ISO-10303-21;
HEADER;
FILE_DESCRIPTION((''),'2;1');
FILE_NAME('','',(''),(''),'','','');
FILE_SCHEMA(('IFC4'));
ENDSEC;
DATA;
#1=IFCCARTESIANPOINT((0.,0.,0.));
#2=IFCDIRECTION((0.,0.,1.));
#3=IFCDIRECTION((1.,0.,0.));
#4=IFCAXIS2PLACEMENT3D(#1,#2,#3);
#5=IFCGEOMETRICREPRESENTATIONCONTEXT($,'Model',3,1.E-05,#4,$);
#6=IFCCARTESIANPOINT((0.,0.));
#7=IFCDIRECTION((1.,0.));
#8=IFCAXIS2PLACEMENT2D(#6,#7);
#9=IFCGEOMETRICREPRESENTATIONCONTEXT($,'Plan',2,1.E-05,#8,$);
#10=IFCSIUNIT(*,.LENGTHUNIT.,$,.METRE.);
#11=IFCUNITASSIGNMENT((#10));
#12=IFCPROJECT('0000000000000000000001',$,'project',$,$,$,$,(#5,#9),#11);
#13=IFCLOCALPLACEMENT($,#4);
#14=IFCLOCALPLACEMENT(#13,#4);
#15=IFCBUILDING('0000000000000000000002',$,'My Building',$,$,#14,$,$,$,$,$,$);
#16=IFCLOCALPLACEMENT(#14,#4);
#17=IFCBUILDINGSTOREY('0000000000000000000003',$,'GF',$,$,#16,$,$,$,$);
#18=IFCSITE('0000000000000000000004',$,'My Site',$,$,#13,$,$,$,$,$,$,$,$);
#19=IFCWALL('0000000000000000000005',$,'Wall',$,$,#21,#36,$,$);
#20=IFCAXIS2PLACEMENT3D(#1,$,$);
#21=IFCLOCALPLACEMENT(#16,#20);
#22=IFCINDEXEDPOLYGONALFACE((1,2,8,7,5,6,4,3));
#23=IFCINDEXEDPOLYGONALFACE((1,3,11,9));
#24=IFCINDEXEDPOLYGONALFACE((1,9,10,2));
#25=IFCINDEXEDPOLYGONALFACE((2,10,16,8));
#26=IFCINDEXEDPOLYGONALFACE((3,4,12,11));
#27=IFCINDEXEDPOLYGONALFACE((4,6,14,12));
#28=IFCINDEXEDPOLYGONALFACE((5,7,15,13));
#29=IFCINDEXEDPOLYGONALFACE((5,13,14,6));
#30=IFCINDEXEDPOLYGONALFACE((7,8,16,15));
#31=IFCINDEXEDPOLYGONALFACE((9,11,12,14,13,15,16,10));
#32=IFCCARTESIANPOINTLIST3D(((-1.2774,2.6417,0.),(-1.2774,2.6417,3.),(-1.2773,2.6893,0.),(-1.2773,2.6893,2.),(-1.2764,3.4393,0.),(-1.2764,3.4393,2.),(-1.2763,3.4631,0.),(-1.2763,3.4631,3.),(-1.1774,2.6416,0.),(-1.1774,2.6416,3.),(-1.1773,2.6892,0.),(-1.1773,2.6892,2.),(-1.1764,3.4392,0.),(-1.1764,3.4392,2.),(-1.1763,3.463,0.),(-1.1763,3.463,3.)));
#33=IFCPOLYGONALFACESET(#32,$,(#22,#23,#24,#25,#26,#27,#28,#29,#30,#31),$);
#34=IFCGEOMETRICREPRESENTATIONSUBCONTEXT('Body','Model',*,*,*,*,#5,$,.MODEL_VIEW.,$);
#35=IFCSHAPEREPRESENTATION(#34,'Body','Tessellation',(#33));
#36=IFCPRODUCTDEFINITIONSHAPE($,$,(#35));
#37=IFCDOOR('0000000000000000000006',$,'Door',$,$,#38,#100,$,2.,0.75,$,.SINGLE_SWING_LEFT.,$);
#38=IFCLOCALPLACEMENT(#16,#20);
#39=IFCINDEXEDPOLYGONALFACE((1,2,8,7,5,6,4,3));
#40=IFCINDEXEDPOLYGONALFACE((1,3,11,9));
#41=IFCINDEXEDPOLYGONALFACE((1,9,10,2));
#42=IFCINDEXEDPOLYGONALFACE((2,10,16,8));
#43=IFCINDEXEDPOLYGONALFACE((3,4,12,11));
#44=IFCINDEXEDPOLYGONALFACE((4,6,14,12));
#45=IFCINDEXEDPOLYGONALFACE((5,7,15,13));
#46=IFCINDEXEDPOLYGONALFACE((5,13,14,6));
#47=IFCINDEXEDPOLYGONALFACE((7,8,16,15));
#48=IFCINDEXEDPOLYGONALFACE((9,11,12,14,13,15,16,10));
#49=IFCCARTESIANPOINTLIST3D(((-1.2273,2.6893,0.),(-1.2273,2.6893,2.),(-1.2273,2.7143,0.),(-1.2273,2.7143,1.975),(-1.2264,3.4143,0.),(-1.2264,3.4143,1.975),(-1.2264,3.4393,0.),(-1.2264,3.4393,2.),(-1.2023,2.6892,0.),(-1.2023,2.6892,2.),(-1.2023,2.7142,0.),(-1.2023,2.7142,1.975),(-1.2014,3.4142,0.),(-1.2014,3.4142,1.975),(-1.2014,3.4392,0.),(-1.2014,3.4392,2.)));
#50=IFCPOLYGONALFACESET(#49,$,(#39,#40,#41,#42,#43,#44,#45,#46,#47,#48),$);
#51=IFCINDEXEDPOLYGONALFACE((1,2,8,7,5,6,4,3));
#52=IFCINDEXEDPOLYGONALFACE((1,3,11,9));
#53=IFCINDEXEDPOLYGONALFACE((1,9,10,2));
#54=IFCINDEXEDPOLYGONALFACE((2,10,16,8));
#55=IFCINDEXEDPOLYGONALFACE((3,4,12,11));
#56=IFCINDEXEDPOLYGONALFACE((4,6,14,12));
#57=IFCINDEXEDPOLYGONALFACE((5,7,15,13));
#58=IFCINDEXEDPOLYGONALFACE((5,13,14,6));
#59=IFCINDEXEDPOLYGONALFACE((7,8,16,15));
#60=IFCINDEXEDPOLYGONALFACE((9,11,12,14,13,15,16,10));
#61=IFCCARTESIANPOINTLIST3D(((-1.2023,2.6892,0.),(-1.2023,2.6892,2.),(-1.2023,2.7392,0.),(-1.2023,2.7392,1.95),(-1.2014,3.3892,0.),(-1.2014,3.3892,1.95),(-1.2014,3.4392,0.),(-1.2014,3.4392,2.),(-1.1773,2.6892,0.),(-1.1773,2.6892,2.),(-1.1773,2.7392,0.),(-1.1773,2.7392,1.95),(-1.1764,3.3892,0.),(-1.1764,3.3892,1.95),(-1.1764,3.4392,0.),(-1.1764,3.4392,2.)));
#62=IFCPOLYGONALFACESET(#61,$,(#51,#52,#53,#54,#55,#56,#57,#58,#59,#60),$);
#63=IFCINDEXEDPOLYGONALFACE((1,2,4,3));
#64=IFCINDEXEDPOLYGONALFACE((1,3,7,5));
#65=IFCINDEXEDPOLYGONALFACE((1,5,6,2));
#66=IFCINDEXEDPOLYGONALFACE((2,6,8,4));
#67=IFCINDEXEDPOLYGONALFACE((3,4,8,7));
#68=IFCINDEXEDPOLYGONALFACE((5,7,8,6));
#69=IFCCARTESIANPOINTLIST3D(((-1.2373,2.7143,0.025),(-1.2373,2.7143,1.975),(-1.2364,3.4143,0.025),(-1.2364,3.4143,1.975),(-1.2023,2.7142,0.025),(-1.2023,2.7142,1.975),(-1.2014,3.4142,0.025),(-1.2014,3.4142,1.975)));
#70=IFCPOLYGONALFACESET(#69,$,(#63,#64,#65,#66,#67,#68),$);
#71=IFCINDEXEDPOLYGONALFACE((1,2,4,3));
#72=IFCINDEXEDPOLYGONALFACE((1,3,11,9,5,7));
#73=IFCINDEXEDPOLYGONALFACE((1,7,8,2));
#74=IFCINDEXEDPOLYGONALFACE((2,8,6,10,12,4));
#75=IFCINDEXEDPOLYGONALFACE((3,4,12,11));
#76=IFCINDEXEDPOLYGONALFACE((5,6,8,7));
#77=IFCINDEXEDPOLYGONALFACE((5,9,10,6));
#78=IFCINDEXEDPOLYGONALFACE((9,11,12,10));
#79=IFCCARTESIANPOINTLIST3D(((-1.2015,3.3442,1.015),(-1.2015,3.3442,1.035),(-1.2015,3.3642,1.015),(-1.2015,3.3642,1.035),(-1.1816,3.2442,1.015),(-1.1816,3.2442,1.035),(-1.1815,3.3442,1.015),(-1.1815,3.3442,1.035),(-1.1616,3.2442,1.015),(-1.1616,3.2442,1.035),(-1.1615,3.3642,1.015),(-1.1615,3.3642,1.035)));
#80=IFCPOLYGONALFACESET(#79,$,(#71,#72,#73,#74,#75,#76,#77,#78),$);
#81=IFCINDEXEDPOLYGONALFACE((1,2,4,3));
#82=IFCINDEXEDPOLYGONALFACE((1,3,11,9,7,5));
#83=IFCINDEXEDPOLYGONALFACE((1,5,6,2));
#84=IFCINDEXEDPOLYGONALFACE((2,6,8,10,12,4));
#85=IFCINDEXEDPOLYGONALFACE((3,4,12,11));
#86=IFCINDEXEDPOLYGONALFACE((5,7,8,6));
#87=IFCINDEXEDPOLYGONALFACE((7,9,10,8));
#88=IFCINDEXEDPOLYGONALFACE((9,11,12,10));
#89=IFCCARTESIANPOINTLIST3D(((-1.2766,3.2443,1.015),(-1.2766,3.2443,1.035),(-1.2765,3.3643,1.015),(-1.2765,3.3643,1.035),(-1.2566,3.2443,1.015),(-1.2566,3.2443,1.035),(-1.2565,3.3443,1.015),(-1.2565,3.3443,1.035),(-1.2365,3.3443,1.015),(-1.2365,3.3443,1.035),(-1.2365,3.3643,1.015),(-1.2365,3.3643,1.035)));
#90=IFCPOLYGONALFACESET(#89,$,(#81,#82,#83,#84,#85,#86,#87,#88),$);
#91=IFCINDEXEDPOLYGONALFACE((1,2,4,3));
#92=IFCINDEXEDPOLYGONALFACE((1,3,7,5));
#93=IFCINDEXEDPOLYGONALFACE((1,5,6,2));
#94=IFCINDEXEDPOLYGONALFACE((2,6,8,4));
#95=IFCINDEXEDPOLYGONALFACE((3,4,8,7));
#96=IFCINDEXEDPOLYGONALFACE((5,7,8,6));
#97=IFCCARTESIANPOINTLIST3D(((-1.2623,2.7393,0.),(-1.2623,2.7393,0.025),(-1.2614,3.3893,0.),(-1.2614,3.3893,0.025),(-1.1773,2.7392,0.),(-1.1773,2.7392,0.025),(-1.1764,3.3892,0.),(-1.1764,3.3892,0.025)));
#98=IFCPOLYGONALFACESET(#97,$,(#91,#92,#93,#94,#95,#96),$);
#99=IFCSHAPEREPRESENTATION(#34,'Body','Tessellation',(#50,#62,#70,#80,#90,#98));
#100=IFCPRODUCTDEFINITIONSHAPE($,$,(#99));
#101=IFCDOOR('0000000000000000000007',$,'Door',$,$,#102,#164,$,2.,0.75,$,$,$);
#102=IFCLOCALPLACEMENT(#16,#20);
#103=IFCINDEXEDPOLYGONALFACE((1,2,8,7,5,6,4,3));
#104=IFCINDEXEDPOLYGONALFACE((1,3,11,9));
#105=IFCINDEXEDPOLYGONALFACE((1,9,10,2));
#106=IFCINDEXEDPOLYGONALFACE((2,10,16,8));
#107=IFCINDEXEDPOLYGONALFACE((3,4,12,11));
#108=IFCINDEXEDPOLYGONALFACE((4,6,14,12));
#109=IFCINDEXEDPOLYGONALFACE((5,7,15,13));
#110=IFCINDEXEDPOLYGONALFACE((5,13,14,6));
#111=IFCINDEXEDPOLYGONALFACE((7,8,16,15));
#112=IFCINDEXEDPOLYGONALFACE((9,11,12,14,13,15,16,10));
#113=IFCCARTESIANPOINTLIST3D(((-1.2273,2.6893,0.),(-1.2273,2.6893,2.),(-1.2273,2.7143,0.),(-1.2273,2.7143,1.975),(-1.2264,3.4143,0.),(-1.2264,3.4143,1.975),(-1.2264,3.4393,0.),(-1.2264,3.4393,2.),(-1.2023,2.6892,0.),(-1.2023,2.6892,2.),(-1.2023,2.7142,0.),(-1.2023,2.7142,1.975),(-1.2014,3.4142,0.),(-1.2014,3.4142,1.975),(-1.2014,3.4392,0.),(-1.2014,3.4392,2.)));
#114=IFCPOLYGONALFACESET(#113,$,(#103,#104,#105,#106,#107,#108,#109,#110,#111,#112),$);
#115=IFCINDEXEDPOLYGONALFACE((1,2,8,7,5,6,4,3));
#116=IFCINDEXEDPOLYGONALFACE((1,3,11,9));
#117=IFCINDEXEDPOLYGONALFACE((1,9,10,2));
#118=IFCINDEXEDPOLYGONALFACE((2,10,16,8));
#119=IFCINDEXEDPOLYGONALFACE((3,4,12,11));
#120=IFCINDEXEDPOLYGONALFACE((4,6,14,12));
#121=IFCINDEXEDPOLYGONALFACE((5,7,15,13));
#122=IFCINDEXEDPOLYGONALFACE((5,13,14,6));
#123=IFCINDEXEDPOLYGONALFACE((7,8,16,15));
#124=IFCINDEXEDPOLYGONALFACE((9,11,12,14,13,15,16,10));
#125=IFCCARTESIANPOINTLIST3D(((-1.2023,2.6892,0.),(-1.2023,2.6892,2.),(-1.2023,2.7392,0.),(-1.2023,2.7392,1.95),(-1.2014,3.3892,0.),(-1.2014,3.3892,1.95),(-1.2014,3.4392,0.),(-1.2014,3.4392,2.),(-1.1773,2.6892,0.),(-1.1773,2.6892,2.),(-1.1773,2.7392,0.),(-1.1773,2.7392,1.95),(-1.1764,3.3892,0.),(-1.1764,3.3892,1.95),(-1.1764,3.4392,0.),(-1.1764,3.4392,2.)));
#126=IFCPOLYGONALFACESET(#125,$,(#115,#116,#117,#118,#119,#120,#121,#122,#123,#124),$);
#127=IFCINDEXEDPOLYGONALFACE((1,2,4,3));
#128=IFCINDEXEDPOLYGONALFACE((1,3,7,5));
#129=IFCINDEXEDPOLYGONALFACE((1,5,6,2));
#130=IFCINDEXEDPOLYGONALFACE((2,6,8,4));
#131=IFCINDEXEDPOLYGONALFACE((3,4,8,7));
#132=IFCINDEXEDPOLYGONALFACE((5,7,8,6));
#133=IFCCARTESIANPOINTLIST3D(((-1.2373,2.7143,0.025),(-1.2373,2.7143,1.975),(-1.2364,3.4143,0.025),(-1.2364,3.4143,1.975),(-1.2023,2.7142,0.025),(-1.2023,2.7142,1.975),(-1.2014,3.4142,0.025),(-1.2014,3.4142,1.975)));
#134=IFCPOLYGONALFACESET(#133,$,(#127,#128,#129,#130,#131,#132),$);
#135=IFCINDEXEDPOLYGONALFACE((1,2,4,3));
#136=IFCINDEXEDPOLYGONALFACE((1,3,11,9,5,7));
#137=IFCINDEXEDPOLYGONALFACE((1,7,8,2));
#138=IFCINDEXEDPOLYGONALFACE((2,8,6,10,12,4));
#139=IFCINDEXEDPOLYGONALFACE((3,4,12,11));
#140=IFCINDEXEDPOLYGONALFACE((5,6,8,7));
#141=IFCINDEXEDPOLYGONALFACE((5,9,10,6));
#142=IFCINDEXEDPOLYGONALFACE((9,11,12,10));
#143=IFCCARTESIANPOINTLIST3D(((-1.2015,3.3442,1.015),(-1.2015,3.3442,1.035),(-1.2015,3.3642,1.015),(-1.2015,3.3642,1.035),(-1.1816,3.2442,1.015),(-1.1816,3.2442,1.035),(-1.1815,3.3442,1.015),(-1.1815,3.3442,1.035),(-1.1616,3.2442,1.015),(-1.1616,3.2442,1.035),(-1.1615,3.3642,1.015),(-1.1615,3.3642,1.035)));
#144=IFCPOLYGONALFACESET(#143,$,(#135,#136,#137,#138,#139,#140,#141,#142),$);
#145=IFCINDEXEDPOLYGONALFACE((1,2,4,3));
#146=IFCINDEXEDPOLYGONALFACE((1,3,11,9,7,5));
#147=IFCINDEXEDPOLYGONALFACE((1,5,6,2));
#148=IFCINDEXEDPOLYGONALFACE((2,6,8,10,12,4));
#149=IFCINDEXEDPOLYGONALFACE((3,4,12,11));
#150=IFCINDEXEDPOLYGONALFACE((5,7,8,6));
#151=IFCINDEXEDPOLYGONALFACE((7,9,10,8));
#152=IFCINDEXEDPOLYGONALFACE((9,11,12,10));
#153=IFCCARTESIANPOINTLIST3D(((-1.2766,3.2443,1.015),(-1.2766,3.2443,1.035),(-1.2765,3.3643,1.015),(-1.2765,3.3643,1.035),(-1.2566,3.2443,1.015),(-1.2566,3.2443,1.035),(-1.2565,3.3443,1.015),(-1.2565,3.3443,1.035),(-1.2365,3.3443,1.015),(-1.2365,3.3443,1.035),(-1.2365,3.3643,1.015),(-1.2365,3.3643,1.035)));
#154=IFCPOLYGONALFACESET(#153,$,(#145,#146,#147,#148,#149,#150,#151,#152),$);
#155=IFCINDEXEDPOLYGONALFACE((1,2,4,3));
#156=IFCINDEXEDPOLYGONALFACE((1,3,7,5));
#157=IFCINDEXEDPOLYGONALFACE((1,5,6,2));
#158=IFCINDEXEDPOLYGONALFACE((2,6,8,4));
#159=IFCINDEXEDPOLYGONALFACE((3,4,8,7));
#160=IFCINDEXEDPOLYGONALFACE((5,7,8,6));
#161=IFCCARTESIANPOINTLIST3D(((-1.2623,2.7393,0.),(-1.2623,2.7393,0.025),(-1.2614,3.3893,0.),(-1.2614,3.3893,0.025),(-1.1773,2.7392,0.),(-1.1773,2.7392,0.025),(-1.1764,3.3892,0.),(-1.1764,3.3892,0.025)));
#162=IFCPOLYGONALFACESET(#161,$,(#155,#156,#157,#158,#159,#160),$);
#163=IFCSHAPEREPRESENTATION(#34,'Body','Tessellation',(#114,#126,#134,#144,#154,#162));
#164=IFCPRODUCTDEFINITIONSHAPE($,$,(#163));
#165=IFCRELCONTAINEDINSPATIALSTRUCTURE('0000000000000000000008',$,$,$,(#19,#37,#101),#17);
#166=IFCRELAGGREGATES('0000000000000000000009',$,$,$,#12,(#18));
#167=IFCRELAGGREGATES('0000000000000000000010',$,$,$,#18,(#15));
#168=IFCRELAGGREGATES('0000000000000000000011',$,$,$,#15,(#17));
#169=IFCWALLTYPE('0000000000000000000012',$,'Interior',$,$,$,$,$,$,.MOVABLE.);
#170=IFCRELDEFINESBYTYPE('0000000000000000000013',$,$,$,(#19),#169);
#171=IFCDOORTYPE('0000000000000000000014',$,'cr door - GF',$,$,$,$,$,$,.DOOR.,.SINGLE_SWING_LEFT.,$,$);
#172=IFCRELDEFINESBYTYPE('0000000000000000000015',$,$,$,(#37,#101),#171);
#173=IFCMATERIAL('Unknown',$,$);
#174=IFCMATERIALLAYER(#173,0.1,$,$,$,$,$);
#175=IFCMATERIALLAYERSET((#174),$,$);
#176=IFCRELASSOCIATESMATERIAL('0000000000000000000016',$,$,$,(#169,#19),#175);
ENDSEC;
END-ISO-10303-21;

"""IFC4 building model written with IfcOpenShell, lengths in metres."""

from ifc_helpers import new_model, entity, si_unit, frame, origin_with_axes, origin_2d_with_axis, place, context, subcontext, project, spatial, line, indexed_curve, outline, extrude, shape, source, transform, mapped, material, layer, layer_set, layer_usage, type_object, type_shapes, element, fill, save


model = new_model("IFC4")

# Units and contexts
model_context = context("Model", 3, precision=1e-05, world=origin_with_axes())
plan_context = context("Plan", 2, precision=1e-05, world=origin_2d_with_axis())
body_context_1 = subcontext(model_context, "Body", "Model", "MODEL_VIEW")
body_context_2 = subcontext(plan_context, "Body", "Plan", "PLAN_VIEW")
ifc_project = project(units=[si_unit("LENGTHUNIT", "METRE")], contexts=[model_context, plan_context])

# Site, building, storey
site_placement = place(None, origin_with_axes())
site = spatial("IfcSite", under=ifc_project, at=site_placement, Name="My Site")
building_placement = place(site_placement, origin_with_axes())
building = spatial("IfcBuilding", under=site, at=building_placement, Name="My Building")
storey_placement = place(building_placement, origin_with_axes())
storey = spatial("IfcBuildingStorey", under=building, at=storey_placement, Name="GF")

# Shared definitions
ifc_material = material(Name="Unknown")

# Shared definitions
ifc_layer_1 = layer(ifc_material, 0.1)
ifc_layer_set_1 = layer_set([ifc_layer_1])
wall_type_1 = type_object("IfcWallType", Name="Interior", PredefinedType="MOVABLE", material=ifc_layer_set_1)

# Wall, openings, doors
ifc_layer_usage_1 = layer_usage(ifc_layer_set_1, "AXIS2", "POSITIVE", 0.0)
wall_1_placement = place(storey_placement, frame((-1.2763, 3.4631, 0.0), z_axis=(0.0, 0.0, 1.0), x_axis=(-0.001302, -0.999999, 0.0)))
wall_1 = element("IfcWall", 1, at=wall_1_placement, inside=storey, type_object=wall_type_1, material=ifc_layer_usage_1, Name="Wall", context=body_context_1, shape_type="SweptSolid", body=[
    extrude(outline(indexed_curve([(0.0, 0.0), (0.0, 0.1), (0.8215, 0.1), (0.8215, 0.0)], segments=[line(1, 2, 3, 4, 1)])), origin_with_axes(), (0.0, 0.0, 1.0), 3.0),
])
shared_shape_1 = source(origin_with_axes(), body_context_1, "Body", "SweptSolid", [
    extrude(outline(indexed_curve([(0.0, 0.0), (0.75, 0.0), (0.75, 2.0), (0.0, 2.0)], segments=[line(1, 2, 3, 4, 1)])), frame((0.0, -0.6, 0.0), z_axis=(0.0, -1.0, 0.0), x_axis=(1.0, 0.0, 0.0)), (0.0, 0.0, -1.0), 1.2),
])
opening_1_placement = place(wall_1_placement, frame((0.7738, 0.1, 0.0), z_axis=(0.0, 0.0, 1.0), x_axis=(-1.0, 0.0, 0.0)))
opening_1 = element("IfcOpeningElement", 2, at=opening_1_placement, cuts=wall_1, PredefinedType="OPENING", context=body_context_1, shape_type="MappedRepresentation", body=[
    mapped(shared_shape_1, transform((0.0, 0.0, 0.0), x_axis=(1.0, 0.0, 0.0), y_axis=(0.0, 1.0, 0.0), z_axis=(0.0, 0.0, 1.0), scale=1.0)),
])
opening_2_placement = place(wall_1_placement, frame((0.7738, 0.1, 0.0), z_axis=(0.0, 0.0, 1.0), x_axis=(-1.0, 0.0, 0.0)))
opening_2 = element("IfcOpeningElement", 3, at=opening_2_placement, cuts=wall_1, PredefinedType="OPENING", context=body_context_1, shape_type="MappedRepresentation", body=[
    mapped(shared_shape_1, transform((0.0, 0.0, 0.0), x_axis=(1.0, 0.0, 0.0), y_axis=(0.0, 1.0, 0.0), z_axis=(0.0, 0.0, 1.0), scale=1.0)),
])
door_type_1 = type_object("IfcDoorType", Name="cr door - GF", OperationType="SINGLE_SWING_LEFT", PredefinedType="DOOR")
shared_shape_2 = source(origin_with_axes(), body_context_1, "Body", "SweptSolid", [
    extrude(outline(indexed_curve([(0.0, 0.0), (0.0, 2.0), (0.75, 2.0), (0.75, 0.0), (0.725, 0.0), (0.725, 1.975), (0.025, 1.975), (0.025, 0.0)], segments=[line(1, 2, 3, 4, 5, 6, 7, 8, 1)])), frame((0.0, 0.025, 0.0), z_axis=(0.0, -1.0, 0.0), x_axis=(1.0, 0.0, 0.0)), (0.0, 0.0, -1.0), 0.025),
    extrude(outline(indexed_curve([(0.0, 0.0), (0.0, 2.0), (0.75, 2.0), (0.75, 0.0), (0.7, 0.0), (0.7, 1.95), (0.05, 1.95), (0.05, 0.0)], segments=[line(1, 2, 3, 4, 5, 6, 7, 8, 1)])), frame((0.0, 0.0, 0.0), z_axis=(0.0, -1.0, 0.0), x_axis=(1.0, 0.0, 0.0)), (0.0, 0.0, -1.0), 0.025),
    extrude(outline(indexed_curve([(0.0, 0.0), (0.7, 0.0), (0.7, 0.035), (0.0, 0.035)], segments=[line(1, 2, 3, 4, 1)])), frame((0.025, 0.025, 0.025), z_axis=(0.0, 0.0, 1.0), x_axis=(1.0, 0.0, 0.0)), (0.0, 0.0, 1.0), 1.95),
    extrude(outline(indexed_curve([(0.0, 0.0), (0.0, -0.04), (-0.12, -0.04), (-0.12, -0.02), (-0.02, -0.02), (-0.02, 0.0)], segments=[line(1, 2, 3, 4, 5, 6, 1)])), frame((0.675, 0.025, 1.015), z_axis=(0.0, 0.0, 1.0), x_axis=(1.0, 0.0, 0.0)), (0.0, 0.0, 1.0), 0.02),
    extrude(outline(indexed_curve([(0.0, 0.0), (0.0, 0.04), (-0.12, 0.04), (-0.12, 0.02), (-0.02, 0.02), (-0.02, 0.0)], segments=[line(1, 2, 3, 4, 5, 6, 1)])), frame((0.675, 0.06, 1.015), z_axis=(0.0, 0.0, 1.0), x_axis=(1.0, 0.0, 0.0)), (0.0, 0.0, 1.0), 0.02),
    extrude(outline(indexed_curve([(0.0, 0.0), (0.65, 0.0), (0.65, 0.085), (0.0, 0.085)], segments=[line(1, 2, 3, 4, 1)])), frame((0.05, 0.0, 0.0), z_axis=(0.0, 0.0, 1.0), x_axis=(1.0, 0.0, 0.0)), (0.0, 0.0, 1.0), 0.025),
])
shared_shape_3 = source(origin_with_axes(), body_context_2, "Body", "Curve2D", [
    entity("IfcIndexedPolyCurve", entity("IfcCartesianPointList2D", [[0.0, 0.0], [0.0, 0.05], [0.025, 0.05], [0.025, 0.025], [0.05, 0.025], [0.05, 0.0]]), [entity("IfcLineIndex", [1, 2, 3, 4, 5, 6, 1])]),
    entity("IfcIndexedPolyCurve", entity("IfcCartesianPointList2D", [[0.75, 0.0], [0.75, 0.05], [0.725, 0.05], [0.725, 0.025], [0.7, 0.025], [0.7, 0.0]]), [entity("IfcLineIndex", [1, 2, 3, 4, 5, 6, 1])]),
    entity("IfcTrimmedCurve", entity("IfcEllipse", entity("IfcAxis2Placement2D", entity("IfcCartesianPoint", [0.06, 0.05]), entity("IfcDirection", [1.0, 0.0])), 0.665, 0.7), [entity("IfcCartesianPoint", [0.725, 0.05])], [entity("IfcCartesianPoint", [0.06, 0.75])], True, "CARTESIAN"),
    entity("IfcIndexedPolyCurve", entity("IfcCartesianPointList2D", [[0.025, 0.05], [0.06, 0.05], [0.06, 0.75], [0.025, 0.75]]), [entity("IfcLineIndex", [1, 2, 3, 4, 1])]),
])
type_shapes(door_type_1, [shared_shape_2, shared_shape_3])
door_1_placement = place(opening_1_placement, frame((0.0, 0.0, 0.0), z_axis=(0.0, 0.0, 1.0), x_axis=(1.0, 0.0, 0.0)))
door_1 = element("IfcDoor", 4, at=door_1_placement, inside=storey, type_object=door_type_1, Name="Door", OperationType="SINGLE_SWING_LEFT", OverallHeight=2.0, OverallWidth=0.75, shapes=[
    shape(body_context_1, "Body", "MappedRepresentation", [mapped(shared_shape_2, transform((0.0, 0.0, 0.0), x_axis=(1.0, 0.0, 0.0), y_axis=(0.0, 1.0, 0.0), z_axis=(0.0, 0.0, 1.0), scale=1.0))]),
    shape(body_context_2, "Body", "MappedRepresentation", [mapped(shared_shape_3, transform((0.0, 0.0, 0.0), x_axis=(1.0, 0.0, 0.0), y_axis=(0.0, 1.0, 0.0), z_axis=(0.0, 0.0, 1.0), scale=1.0))]),
])
fill(opening_1, door_1)
door_2_placement = place(opening_2_placement, frame((0.0, 0.0, 0.0), z_axis=(0.0, 0.0, 1.0), x_axis=(1.0, 0.0, 0.0)))
door_2 = element("IfcDoor", 5, at=door_2_placement, inside=storey, type_object=door_type_1, Name="Door", OverallHeight=2.0, OverallWidth=0.75, shapes=[
    shape(body_context_1, "Body", "MappedRepresentation", [mapped(shared_shape_2, transform((0.0, 0.0, 0.0), x_axis=(1.0, 0.0, 0.0), y_axis=(0.0, 1.0, 0.0), z_axis=(0.0, 0.0, 1.0), scale=1.0))]),
    shape(body_context_2, "Body", "MappedRepresentation", [mapped(shared_shape_3, transform((0.0, 0.0, 0.0), x_axis=(1.0, 0.0, 0.0), y_axis=(0.0, 1.0, 0.0), z_axis=(0.0, 0.0, 1.0), scale=1.0))]),
])
fill(opening_2, door_2)

save(model, "model.ifc")
